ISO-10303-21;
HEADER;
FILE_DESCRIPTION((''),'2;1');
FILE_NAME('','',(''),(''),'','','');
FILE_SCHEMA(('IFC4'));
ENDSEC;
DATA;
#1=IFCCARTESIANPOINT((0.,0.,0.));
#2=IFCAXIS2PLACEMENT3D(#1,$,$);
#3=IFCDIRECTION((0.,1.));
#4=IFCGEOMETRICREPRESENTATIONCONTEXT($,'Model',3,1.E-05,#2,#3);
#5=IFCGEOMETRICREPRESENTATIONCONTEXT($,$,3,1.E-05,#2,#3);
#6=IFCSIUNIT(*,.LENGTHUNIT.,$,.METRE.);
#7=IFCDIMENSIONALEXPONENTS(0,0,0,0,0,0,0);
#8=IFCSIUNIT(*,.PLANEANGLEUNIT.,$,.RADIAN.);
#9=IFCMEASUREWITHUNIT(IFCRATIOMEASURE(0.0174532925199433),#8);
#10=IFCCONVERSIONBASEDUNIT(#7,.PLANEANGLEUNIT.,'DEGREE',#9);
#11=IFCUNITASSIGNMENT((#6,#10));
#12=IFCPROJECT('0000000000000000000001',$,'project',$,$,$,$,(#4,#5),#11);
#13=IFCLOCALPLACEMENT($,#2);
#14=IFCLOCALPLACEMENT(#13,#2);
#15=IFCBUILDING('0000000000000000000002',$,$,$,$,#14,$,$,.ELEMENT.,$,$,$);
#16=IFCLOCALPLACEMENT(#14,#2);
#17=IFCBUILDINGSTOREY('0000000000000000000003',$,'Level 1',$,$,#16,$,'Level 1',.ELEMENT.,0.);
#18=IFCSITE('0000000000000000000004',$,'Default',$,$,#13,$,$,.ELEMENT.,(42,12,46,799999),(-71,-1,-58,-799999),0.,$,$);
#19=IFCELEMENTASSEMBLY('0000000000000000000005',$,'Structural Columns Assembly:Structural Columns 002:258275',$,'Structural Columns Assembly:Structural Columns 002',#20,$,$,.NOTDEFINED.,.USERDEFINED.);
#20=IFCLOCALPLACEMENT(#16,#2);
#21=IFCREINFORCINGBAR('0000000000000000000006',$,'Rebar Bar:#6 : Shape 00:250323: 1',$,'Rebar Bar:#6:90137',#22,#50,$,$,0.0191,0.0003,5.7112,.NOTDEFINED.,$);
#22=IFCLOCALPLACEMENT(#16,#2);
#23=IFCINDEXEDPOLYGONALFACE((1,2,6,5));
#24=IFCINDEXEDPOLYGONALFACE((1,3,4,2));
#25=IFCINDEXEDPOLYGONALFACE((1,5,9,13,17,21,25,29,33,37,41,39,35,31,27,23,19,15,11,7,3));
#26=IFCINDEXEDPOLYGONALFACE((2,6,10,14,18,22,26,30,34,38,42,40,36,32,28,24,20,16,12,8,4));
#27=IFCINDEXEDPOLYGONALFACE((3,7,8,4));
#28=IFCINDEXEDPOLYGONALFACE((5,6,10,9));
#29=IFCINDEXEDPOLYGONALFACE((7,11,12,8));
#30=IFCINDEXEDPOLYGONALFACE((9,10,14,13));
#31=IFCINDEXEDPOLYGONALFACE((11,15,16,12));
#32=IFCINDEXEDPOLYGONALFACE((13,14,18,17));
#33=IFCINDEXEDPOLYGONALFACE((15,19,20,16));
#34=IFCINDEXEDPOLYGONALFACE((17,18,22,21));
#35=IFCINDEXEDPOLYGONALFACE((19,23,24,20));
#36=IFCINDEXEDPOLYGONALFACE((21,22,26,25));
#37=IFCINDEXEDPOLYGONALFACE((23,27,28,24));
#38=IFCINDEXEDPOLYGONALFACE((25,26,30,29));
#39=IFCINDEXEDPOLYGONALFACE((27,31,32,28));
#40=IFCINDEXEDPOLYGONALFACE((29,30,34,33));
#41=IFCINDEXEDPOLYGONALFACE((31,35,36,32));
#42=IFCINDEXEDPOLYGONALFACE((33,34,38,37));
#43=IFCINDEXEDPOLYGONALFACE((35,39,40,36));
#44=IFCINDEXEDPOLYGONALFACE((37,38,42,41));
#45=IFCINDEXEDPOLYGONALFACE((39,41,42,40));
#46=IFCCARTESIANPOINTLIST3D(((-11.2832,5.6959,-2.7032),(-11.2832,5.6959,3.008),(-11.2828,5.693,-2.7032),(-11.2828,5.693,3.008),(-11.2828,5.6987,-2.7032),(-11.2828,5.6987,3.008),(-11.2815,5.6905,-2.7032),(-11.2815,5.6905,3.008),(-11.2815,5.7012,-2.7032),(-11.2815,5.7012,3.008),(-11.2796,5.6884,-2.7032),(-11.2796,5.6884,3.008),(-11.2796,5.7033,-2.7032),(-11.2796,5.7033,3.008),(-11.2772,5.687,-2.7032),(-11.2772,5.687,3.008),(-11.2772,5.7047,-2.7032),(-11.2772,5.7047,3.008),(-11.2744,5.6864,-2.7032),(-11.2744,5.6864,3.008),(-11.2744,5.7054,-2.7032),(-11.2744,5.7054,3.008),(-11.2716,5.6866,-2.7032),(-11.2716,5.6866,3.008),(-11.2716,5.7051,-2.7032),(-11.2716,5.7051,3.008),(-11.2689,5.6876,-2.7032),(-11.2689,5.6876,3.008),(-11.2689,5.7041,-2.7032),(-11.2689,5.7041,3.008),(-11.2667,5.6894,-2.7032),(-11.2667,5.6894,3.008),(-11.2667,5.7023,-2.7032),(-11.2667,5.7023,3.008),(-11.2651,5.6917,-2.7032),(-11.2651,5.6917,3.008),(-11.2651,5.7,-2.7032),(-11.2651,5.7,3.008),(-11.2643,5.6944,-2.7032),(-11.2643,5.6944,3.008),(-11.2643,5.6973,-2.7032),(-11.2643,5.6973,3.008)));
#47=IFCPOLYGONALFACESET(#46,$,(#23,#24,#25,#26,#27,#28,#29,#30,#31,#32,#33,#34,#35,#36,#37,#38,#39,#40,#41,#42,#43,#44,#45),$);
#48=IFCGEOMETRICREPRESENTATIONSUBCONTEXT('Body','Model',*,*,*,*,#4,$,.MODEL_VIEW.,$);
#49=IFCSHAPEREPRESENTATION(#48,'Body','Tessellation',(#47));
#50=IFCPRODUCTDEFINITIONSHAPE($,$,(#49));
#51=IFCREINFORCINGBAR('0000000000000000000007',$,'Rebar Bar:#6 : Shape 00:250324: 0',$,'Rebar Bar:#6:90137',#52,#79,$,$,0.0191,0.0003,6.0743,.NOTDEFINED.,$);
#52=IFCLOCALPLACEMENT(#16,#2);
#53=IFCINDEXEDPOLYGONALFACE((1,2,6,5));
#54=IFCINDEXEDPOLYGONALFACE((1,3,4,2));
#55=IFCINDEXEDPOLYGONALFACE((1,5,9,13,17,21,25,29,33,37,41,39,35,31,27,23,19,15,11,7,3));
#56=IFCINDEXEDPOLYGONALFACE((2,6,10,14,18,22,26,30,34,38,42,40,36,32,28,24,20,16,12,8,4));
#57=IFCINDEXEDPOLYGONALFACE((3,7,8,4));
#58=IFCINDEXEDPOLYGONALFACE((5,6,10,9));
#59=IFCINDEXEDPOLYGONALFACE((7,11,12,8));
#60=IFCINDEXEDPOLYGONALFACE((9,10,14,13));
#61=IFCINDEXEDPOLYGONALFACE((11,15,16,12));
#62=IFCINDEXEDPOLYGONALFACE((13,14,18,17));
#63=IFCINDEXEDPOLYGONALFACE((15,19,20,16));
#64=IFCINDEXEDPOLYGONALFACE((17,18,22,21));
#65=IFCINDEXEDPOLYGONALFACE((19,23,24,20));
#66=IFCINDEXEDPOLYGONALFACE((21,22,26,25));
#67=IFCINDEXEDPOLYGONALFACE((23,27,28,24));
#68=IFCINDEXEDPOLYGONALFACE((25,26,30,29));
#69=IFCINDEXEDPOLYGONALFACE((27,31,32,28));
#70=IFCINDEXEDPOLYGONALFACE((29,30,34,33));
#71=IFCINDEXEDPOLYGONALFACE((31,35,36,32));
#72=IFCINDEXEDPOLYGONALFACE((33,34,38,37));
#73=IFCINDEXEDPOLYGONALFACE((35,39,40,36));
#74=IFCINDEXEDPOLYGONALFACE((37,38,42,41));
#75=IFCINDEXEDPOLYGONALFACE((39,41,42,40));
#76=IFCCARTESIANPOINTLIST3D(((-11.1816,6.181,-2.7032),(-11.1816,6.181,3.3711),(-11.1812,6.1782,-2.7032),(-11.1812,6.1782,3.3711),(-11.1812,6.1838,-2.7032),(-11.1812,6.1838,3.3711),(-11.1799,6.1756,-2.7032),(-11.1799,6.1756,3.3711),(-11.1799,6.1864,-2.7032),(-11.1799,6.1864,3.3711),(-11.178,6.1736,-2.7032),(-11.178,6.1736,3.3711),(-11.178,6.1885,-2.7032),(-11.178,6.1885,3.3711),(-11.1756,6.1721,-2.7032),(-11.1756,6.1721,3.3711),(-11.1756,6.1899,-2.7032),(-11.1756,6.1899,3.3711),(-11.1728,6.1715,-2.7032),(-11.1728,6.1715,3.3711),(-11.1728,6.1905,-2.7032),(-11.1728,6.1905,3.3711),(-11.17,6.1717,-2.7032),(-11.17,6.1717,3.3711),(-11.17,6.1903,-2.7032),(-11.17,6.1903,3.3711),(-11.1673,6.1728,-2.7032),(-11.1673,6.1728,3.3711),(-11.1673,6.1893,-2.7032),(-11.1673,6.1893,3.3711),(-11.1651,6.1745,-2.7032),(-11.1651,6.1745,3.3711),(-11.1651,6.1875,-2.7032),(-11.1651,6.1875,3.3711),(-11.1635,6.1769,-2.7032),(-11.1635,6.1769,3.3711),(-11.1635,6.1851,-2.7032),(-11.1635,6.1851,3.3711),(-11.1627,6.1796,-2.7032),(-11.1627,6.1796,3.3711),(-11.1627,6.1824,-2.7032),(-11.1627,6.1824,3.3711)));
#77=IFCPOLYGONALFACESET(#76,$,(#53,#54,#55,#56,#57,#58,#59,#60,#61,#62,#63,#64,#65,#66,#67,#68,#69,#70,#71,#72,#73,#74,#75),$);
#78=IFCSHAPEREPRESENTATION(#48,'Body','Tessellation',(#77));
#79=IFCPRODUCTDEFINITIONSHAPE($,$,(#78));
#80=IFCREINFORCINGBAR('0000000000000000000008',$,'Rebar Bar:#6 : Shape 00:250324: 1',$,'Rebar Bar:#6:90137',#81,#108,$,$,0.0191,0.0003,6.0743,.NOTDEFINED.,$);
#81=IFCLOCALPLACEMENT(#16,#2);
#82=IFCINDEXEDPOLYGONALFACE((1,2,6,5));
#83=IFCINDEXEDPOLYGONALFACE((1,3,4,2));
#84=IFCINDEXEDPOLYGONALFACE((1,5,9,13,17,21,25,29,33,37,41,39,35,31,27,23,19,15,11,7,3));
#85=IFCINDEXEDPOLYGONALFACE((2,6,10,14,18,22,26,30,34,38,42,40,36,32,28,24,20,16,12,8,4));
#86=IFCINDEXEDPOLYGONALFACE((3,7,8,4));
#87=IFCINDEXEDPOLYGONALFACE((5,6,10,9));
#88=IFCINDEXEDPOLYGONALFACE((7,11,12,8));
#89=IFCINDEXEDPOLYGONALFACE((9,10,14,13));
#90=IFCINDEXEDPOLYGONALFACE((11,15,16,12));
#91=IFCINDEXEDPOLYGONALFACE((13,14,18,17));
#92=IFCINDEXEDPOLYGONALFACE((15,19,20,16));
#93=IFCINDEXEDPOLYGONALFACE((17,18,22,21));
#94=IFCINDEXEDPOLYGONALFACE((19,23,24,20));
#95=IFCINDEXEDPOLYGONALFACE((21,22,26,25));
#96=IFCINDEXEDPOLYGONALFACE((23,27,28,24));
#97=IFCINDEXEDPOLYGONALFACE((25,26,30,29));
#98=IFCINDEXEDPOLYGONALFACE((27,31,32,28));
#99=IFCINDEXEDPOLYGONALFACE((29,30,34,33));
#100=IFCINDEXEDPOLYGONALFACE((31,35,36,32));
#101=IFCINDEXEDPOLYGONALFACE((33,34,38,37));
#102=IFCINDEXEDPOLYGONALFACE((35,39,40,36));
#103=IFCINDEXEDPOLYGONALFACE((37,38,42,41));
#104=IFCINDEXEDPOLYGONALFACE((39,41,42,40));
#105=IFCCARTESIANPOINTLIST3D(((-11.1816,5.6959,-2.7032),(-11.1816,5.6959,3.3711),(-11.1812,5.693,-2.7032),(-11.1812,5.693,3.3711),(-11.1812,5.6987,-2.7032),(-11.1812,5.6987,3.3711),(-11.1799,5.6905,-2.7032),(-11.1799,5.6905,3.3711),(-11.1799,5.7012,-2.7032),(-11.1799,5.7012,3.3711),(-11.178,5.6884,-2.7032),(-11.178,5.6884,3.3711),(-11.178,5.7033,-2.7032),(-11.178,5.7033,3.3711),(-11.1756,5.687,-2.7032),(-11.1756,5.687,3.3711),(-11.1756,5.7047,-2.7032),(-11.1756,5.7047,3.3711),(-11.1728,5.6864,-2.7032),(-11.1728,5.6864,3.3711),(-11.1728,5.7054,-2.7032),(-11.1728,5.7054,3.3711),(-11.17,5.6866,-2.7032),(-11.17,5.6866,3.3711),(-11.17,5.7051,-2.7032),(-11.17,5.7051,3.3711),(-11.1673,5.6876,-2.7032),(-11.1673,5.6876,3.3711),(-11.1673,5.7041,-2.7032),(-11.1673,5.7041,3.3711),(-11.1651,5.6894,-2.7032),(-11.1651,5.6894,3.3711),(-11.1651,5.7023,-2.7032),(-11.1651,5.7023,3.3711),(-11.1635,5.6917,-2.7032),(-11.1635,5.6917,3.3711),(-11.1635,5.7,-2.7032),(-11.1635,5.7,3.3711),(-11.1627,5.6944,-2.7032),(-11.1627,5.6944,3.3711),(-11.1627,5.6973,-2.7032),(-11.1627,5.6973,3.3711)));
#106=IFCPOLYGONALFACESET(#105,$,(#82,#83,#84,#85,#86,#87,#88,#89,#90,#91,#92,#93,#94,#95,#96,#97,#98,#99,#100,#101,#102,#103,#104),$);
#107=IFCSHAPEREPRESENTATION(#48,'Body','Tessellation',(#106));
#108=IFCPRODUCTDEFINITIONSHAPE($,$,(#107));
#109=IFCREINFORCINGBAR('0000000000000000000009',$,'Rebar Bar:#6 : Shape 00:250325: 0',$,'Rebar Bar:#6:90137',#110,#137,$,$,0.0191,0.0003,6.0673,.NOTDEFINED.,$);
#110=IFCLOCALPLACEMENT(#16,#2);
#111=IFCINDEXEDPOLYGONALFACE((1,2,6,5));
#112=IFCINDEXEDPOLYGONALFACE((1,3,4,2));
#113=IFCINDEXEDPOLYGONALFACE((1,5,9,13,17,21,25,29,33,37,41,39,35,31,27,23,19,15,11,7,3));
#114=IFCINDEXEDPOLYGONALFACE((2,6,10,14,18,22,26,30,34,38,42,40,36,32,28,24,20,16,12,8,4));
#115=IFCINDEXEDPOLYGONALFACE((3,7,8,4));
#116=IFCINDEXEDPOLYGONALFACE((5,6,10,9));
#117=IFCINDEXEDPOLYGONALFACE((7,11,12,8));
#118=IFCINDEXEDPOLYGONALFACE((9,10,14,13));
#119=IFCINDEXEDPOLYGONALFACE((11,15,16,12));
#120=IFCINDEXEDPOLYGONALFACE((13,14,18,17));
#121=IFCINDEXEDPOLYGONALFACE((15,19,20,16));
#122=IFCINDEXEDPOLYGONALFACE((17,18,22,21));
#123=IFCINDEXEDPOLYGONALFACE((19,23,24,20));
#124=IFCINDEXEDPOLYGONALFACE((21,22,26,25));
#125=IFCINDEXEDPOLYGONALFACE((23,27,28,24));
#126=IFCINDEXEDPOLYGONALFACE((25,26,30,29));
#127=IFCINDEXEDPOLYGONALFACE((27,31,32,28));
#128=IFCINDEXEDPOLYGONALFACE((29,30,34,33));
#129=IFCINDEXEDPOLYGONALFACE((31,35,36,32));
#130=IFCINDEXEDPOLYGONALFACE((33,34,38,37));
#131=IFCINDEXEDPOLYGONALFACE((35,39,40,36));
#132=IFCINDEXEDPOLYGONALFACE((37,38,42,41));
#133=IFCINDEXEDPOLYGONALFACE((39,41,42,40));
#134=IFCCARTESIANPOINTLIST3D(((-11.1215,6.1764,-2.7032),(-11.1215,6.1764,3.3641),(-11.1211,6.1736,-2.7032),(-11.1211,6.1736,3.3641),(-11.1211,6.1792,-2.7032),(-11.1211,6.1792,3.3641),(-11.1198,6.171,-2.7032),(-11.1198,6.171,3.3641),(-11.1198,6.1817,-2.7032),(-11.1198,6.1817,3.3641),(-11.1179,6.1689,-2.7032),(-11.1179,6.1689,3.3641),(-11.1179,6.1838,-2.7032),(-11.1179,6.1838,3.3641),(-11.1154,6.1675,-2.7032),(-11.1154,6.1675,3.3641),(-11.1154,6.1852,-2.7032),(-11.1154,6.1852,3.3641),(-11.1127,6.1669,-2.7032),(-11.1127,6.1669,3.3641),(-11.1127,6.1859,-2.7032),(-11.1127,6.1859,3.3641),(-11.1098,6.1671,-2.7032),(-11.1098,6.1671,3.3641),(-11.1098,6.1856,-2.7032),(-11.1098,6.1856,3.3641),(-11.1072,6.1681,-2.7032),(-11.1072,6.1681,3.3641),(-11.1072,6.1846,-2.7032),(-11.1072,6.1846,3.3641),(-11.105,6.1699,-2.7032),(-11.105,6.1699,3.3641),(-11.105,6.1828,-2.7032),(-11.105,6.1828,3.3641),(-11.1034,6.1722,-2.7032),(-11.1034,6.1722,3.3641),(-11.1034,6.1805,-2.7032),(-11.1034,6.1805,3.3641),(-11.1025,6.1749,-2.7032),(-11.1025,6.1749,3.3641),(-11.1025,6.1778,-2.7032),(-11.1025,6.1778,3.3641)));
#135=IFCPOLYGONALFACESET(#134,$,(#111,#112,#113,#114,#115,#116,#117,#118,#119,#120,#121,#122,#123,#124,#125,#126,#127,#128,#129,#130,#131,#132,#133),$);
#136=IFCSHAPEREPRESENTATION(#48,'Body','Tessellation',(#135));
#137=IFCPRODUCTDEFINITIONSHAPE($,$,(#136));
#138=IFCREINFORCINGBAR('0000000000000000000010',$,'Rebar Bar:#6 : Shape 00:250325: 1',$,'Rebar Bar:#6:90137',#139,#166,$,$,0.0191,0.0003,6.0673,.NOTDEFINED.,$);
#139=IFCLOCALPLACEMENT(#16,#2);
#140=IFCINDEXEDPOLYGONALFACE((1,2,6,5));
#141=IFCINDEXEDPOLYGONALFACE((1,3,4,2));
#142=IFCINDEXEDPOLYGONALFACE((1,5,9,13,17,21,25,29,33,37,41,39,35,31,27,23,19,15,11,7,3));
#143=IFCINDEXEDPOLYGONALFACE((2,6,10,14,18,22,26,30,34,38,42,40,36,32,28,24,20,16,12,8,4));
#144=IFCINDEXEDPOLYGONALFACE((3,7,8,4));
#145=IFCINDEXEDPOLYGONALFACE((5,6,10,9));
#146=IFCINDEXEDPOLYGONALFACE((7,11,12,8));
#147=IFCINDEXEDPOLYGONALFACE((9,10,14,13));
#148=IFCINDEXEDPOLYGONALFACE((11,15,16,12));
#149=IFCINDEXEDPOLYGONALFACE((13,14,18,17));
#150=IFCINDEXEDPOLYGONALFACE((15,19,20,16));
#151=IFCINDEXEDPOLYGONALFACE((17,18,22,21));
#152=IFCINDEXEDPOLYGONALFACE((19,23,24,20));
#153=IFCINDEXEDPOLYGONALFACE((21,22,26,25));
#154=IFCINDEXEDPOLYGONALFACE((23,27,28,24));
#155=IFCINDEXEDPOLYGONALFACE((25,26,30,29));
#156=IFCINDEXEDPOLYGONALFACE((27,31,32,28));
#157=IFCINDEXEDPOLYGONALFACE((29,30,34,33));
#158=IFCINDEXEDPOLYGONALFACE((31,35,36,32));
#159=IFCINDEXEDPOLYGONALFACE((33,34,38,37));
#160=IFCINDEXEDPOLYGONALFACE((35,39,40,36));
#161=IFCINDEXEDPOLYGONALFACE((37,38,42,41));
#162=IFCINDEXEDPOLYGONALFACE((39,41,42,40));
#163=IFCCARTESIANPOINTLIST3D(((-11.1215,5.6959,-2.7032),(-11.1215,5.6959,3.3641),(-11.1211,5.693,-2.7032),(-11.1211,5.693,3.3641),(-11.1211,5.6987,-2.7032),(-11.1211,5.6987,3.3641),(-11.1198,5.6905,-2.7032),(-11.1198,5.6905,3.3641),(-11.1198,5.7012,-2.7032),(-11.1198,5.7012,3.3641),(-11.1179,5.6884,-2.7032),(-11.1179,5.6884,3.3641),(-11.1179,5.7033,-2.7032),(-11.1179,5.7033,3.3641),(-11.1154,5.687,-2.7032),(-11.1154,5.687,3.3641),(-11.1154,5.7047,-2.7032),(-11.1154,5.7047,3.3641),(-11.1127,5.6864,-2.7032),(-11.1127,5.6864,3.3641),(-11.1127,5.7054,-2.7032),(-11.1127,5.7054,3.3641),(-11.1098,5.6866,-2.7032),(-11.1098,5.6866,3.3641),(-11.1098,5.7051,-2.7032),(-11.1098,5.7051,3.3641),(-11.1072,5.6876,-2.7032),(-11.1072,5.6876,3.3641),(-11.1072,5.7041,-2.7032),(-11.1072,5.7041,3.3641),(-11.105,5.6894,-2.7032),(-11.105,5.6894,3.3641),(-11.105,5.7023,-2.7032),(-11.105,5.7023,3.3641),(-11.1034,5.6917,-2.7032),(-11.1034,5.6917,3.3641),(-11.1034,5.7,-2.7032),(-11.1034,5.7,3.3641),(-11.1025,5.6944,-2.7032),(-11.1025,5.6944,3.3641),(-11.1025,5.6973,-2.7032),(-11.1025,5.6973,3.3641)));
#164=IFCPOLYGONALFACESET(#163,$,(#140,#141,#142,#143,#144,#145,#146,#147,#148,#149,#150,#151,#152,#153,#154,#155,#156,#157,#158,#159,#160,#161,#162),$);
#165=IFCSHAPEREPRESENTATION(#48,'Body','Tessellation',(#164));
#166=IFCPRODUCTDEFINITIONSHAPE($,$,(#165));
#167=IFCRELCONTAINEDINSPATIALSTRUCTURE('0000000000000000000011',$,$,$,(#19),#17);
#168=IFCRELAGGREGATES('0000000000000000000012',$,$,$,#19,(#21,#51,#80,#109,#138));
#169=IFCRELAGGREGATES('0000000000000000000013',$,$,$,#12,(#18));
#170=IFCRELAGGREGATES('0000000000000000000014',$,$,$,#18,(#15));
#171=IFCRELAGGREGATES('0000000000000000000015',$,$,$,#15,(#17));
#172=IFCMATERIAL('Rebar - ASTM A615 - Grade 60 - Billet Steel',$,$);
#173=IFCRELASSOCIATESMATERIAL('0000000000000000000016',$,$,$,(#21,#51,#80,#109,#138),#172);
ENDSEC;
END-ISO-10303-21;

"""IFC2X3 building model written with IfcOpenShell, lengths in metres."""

from ifc_helpers import new_model, entity, si_unit, converted_unit, direction, origin, place, context, subcontext, project, spatial, material, element, aggregate, save


model = new_model("IFC2X3")

# Units and contexts
model_context = context("Model", 3, precision=1e-05, world=origin(), true_north=direction((0.0, 1.0)))
context_of_model = context(None, 3, precision=1e-05, world=origin(), true_north=direction((0.0, 1.0)))
body_context = subcontext(model_context, "Body", "Model", "MODEL_VIEW")
ifc_project = project(units=[si_unit("LENGTHUNIT", "METRE"), converted_unit("PLANEANGLEUNIT", "DEGREE", entity("IfcRatioMeasure", 0.0174532925199433), si_unit("PLANEANGLEUNIT", "RADIAN"), dimensions=[0, 0, 0, 0, 0, 0, 0])], contexts=[model_context, context_of_model])

# Site, building, storey
site_placement = place(None, origin())
site = spatial("IfcSite", under=ifc_project, at=site_placement, Name="Default", CompositionType="ELEMENT", RefLatitude=(42, 12, 46, 799999), RefLongitude=(-71, -1, -58, -799999), RefElevation=0.0)
building_placement = place(site_placement, origin())
building = spatial("IfcBuilding", under=site, at=building_placement, CompositionType="ELEMENT")
storey_placement = place(building_placement, origin())
storey = spatial("IfcBuildingStorey", under=building, at=storey_placement, Name="Level 1", LongName="Level 1", CompositionType="ELEMENT", Elevation=0.0)

# Element assembly, reinforcing bars
assembly_1_placement = place(storey_placement, origin())
assembly_1 = element("IfcElementAssembly", 1, at=assembly_1_placement, inside=storey, Name="Structural Columns Assembly:Structural Columns 002:258275", ObjectType="Structural Columns Assembly:Structural Columns 002", AssemblyPlace="NOTDEFINED", PredefinedType="USERDEFINED")
ifc_material_1 = material(Name="Rebar - ASTM A615 - Grade 60 - Billet Steel")
reinforcing_bar_1_placement = place(assembly_1_placement, origin())
reinforcing_bar_1 = element("IfcReinforcingBar", 2, at=reinforcing_bar_1_placement, material=ifc_material_1, Name="Rebar Bar:#6 : Shape 00:250323: 1", ObjectType="Rebar Bar:#6:90137", BarLength=5.7112, BarRole="NOTDEFINED", CrossSectionArea=0.0003, NominalDiameter=0.0191, context=body_context, shape_type="AdvancedSweptSolid", body=[
    entity("IfcSweptDiskSolid", entity("IfcCompositeCurve", [entity("IfcCompositeCurveSegment", "CONTINUOUS", True, entity("IfcPolyline", [entity("IfcCartesianPoint", [-11.2737, 5.6959, 3.008]), entity("IfcCartesianPoint", [-11.2737, 5.6959, -2.7032])]))], False), 0.0095, None, 0.0, 1.0),
])
reinforcing_bar_2_placement = place(assembly_1_placement, origin())
reinforcing_bar_2 = element("IfcReinforcingBar", 3, at=reinforcing_bar_2_placement, material=ifc_material_1, Name="Rebar Bar:#6 : Shape 00:250324: 0", ObjectType="Rebar Bar:#6:90137", BarLength=6.0743, BarRole="NOTDEFINED", CrossSectionArea=0.0003, NominalDiameter=0.0191, context=body_context, shape_type="AdvancedSweptSolid", body=[
    entity("IfcSweptDiskSolid", entity("IfcCompositeCurve", [entity("IfcCompositeCurveSegment", "CONTINUOUS", True, entity("IfcPolyline", [entity("IfcCartesianPoint", [-11.1721, 6.181, 3.3711]), entity("IfcCartesianPoint", [-11.1721, 6.181, -2.7032])]))], False), 0.0095, None, 0.0, 1.0),
])
reinforcing_bar_3_placement = place(assembly_1_placement, origin())
reinforcing_bar_3 = element("IfcReinforcingBar", 4, at=reinforcing_bar_3_placement, material=ifc_material_1, Name="Rebar Bar:#6 : Shape 00:250324: 1", ObjectType="Rebar Bar:#6:90137", BarLength=6.0743, BarRole="NOTDEFINED", CrossSectionArea=0.0003, NominalDiameter=0.0191, context=body_context, shape_type="AdvancedSweptSolid", body=[
    entity("IfcSweptDiskSolid", entity("IfcCompositeCurve", [entity("IfcCompositeCurveSegment", "CONTINUOUS", True, entity("IfcPolyline", [entity("IfcCartesianPoint", [-11.1721, 5.6959, 3.3711]), entity("IfcCartesianPoint", [-11.1721, 5.6959, -2.7032])]))], False), 0.0095, None, 0.0, 1.0),
])
reinforcing_bar_4_placement = place(assembly_1_placement, origin())
reinforcing_bar_4 = element("IfcReinforcingBar", 5, at=reinforcing_bar_4_placement, material=ifc_material_1, Name="Rebar Bar:#6 : Shape 00:250325: 0", ObjectType="Rebar Bar:#6:90137", BarLength=6.0673, BarRole="NOTDEFINED", CrossSectionArea=0.0003, NominalDiameter=0.0191, context=body_context, shape_type="AdvancedSweptSolid", body=[
    entity("IfcSweptDiskSolid", entity("IfcCompositeCurve", [entity("IfcCompositeCurveSegment", "CONTINUOUS", True, entity("IfcPolyline", [entity("IfcCartesianPoint", [-11.112, 6.1764, 3.3641]), entity("IfcCartesianPoint", [-11.112, 6.1764, -2.7032])]))], False), 0.0095, None, 0.0, 1.0),
])
reinforcing_bar_5_placement = place(assembly_1_placement, origin())
reinforcing_bar_5 = element("IfcReinforcingBar", 6, at=reinforcing_bar_5_placement, material=ifc_material_1, Name="Rebar Bar:#6 : Shape 00:250325: 1", ObjectType="Rebar Bar:#6:90137", BarLength=6.0673, BarRole="NOTDEFINED", CrossSectionArea=0.0003, NominalDiameter=0.0191, context=body_context, shape_type="AdvancedSweptSolid", body=[
    entity("IfcSweptDiskSolid", entity("IfcCompositeCurve", [entity("IfcCompositeCurveSegment", "CONTINUOUS", True, entity("IfcPolyline", [entity("IfcCartesianPoint", [-11.112, 5.6959, 3.3641]), entity("IfcCartesianPoint", [-11.112, 5.6959, -2.7032])]))], False), 0.0095, None, 0.0, 1.0),
])
aggregate(assembly_1, [reinforcing_bar_1, reinforcing_bar_2, reinforcing_bar_3, reinforcing_bar_4, reinforcing_bar_5])

save(model, "model.ifc")
